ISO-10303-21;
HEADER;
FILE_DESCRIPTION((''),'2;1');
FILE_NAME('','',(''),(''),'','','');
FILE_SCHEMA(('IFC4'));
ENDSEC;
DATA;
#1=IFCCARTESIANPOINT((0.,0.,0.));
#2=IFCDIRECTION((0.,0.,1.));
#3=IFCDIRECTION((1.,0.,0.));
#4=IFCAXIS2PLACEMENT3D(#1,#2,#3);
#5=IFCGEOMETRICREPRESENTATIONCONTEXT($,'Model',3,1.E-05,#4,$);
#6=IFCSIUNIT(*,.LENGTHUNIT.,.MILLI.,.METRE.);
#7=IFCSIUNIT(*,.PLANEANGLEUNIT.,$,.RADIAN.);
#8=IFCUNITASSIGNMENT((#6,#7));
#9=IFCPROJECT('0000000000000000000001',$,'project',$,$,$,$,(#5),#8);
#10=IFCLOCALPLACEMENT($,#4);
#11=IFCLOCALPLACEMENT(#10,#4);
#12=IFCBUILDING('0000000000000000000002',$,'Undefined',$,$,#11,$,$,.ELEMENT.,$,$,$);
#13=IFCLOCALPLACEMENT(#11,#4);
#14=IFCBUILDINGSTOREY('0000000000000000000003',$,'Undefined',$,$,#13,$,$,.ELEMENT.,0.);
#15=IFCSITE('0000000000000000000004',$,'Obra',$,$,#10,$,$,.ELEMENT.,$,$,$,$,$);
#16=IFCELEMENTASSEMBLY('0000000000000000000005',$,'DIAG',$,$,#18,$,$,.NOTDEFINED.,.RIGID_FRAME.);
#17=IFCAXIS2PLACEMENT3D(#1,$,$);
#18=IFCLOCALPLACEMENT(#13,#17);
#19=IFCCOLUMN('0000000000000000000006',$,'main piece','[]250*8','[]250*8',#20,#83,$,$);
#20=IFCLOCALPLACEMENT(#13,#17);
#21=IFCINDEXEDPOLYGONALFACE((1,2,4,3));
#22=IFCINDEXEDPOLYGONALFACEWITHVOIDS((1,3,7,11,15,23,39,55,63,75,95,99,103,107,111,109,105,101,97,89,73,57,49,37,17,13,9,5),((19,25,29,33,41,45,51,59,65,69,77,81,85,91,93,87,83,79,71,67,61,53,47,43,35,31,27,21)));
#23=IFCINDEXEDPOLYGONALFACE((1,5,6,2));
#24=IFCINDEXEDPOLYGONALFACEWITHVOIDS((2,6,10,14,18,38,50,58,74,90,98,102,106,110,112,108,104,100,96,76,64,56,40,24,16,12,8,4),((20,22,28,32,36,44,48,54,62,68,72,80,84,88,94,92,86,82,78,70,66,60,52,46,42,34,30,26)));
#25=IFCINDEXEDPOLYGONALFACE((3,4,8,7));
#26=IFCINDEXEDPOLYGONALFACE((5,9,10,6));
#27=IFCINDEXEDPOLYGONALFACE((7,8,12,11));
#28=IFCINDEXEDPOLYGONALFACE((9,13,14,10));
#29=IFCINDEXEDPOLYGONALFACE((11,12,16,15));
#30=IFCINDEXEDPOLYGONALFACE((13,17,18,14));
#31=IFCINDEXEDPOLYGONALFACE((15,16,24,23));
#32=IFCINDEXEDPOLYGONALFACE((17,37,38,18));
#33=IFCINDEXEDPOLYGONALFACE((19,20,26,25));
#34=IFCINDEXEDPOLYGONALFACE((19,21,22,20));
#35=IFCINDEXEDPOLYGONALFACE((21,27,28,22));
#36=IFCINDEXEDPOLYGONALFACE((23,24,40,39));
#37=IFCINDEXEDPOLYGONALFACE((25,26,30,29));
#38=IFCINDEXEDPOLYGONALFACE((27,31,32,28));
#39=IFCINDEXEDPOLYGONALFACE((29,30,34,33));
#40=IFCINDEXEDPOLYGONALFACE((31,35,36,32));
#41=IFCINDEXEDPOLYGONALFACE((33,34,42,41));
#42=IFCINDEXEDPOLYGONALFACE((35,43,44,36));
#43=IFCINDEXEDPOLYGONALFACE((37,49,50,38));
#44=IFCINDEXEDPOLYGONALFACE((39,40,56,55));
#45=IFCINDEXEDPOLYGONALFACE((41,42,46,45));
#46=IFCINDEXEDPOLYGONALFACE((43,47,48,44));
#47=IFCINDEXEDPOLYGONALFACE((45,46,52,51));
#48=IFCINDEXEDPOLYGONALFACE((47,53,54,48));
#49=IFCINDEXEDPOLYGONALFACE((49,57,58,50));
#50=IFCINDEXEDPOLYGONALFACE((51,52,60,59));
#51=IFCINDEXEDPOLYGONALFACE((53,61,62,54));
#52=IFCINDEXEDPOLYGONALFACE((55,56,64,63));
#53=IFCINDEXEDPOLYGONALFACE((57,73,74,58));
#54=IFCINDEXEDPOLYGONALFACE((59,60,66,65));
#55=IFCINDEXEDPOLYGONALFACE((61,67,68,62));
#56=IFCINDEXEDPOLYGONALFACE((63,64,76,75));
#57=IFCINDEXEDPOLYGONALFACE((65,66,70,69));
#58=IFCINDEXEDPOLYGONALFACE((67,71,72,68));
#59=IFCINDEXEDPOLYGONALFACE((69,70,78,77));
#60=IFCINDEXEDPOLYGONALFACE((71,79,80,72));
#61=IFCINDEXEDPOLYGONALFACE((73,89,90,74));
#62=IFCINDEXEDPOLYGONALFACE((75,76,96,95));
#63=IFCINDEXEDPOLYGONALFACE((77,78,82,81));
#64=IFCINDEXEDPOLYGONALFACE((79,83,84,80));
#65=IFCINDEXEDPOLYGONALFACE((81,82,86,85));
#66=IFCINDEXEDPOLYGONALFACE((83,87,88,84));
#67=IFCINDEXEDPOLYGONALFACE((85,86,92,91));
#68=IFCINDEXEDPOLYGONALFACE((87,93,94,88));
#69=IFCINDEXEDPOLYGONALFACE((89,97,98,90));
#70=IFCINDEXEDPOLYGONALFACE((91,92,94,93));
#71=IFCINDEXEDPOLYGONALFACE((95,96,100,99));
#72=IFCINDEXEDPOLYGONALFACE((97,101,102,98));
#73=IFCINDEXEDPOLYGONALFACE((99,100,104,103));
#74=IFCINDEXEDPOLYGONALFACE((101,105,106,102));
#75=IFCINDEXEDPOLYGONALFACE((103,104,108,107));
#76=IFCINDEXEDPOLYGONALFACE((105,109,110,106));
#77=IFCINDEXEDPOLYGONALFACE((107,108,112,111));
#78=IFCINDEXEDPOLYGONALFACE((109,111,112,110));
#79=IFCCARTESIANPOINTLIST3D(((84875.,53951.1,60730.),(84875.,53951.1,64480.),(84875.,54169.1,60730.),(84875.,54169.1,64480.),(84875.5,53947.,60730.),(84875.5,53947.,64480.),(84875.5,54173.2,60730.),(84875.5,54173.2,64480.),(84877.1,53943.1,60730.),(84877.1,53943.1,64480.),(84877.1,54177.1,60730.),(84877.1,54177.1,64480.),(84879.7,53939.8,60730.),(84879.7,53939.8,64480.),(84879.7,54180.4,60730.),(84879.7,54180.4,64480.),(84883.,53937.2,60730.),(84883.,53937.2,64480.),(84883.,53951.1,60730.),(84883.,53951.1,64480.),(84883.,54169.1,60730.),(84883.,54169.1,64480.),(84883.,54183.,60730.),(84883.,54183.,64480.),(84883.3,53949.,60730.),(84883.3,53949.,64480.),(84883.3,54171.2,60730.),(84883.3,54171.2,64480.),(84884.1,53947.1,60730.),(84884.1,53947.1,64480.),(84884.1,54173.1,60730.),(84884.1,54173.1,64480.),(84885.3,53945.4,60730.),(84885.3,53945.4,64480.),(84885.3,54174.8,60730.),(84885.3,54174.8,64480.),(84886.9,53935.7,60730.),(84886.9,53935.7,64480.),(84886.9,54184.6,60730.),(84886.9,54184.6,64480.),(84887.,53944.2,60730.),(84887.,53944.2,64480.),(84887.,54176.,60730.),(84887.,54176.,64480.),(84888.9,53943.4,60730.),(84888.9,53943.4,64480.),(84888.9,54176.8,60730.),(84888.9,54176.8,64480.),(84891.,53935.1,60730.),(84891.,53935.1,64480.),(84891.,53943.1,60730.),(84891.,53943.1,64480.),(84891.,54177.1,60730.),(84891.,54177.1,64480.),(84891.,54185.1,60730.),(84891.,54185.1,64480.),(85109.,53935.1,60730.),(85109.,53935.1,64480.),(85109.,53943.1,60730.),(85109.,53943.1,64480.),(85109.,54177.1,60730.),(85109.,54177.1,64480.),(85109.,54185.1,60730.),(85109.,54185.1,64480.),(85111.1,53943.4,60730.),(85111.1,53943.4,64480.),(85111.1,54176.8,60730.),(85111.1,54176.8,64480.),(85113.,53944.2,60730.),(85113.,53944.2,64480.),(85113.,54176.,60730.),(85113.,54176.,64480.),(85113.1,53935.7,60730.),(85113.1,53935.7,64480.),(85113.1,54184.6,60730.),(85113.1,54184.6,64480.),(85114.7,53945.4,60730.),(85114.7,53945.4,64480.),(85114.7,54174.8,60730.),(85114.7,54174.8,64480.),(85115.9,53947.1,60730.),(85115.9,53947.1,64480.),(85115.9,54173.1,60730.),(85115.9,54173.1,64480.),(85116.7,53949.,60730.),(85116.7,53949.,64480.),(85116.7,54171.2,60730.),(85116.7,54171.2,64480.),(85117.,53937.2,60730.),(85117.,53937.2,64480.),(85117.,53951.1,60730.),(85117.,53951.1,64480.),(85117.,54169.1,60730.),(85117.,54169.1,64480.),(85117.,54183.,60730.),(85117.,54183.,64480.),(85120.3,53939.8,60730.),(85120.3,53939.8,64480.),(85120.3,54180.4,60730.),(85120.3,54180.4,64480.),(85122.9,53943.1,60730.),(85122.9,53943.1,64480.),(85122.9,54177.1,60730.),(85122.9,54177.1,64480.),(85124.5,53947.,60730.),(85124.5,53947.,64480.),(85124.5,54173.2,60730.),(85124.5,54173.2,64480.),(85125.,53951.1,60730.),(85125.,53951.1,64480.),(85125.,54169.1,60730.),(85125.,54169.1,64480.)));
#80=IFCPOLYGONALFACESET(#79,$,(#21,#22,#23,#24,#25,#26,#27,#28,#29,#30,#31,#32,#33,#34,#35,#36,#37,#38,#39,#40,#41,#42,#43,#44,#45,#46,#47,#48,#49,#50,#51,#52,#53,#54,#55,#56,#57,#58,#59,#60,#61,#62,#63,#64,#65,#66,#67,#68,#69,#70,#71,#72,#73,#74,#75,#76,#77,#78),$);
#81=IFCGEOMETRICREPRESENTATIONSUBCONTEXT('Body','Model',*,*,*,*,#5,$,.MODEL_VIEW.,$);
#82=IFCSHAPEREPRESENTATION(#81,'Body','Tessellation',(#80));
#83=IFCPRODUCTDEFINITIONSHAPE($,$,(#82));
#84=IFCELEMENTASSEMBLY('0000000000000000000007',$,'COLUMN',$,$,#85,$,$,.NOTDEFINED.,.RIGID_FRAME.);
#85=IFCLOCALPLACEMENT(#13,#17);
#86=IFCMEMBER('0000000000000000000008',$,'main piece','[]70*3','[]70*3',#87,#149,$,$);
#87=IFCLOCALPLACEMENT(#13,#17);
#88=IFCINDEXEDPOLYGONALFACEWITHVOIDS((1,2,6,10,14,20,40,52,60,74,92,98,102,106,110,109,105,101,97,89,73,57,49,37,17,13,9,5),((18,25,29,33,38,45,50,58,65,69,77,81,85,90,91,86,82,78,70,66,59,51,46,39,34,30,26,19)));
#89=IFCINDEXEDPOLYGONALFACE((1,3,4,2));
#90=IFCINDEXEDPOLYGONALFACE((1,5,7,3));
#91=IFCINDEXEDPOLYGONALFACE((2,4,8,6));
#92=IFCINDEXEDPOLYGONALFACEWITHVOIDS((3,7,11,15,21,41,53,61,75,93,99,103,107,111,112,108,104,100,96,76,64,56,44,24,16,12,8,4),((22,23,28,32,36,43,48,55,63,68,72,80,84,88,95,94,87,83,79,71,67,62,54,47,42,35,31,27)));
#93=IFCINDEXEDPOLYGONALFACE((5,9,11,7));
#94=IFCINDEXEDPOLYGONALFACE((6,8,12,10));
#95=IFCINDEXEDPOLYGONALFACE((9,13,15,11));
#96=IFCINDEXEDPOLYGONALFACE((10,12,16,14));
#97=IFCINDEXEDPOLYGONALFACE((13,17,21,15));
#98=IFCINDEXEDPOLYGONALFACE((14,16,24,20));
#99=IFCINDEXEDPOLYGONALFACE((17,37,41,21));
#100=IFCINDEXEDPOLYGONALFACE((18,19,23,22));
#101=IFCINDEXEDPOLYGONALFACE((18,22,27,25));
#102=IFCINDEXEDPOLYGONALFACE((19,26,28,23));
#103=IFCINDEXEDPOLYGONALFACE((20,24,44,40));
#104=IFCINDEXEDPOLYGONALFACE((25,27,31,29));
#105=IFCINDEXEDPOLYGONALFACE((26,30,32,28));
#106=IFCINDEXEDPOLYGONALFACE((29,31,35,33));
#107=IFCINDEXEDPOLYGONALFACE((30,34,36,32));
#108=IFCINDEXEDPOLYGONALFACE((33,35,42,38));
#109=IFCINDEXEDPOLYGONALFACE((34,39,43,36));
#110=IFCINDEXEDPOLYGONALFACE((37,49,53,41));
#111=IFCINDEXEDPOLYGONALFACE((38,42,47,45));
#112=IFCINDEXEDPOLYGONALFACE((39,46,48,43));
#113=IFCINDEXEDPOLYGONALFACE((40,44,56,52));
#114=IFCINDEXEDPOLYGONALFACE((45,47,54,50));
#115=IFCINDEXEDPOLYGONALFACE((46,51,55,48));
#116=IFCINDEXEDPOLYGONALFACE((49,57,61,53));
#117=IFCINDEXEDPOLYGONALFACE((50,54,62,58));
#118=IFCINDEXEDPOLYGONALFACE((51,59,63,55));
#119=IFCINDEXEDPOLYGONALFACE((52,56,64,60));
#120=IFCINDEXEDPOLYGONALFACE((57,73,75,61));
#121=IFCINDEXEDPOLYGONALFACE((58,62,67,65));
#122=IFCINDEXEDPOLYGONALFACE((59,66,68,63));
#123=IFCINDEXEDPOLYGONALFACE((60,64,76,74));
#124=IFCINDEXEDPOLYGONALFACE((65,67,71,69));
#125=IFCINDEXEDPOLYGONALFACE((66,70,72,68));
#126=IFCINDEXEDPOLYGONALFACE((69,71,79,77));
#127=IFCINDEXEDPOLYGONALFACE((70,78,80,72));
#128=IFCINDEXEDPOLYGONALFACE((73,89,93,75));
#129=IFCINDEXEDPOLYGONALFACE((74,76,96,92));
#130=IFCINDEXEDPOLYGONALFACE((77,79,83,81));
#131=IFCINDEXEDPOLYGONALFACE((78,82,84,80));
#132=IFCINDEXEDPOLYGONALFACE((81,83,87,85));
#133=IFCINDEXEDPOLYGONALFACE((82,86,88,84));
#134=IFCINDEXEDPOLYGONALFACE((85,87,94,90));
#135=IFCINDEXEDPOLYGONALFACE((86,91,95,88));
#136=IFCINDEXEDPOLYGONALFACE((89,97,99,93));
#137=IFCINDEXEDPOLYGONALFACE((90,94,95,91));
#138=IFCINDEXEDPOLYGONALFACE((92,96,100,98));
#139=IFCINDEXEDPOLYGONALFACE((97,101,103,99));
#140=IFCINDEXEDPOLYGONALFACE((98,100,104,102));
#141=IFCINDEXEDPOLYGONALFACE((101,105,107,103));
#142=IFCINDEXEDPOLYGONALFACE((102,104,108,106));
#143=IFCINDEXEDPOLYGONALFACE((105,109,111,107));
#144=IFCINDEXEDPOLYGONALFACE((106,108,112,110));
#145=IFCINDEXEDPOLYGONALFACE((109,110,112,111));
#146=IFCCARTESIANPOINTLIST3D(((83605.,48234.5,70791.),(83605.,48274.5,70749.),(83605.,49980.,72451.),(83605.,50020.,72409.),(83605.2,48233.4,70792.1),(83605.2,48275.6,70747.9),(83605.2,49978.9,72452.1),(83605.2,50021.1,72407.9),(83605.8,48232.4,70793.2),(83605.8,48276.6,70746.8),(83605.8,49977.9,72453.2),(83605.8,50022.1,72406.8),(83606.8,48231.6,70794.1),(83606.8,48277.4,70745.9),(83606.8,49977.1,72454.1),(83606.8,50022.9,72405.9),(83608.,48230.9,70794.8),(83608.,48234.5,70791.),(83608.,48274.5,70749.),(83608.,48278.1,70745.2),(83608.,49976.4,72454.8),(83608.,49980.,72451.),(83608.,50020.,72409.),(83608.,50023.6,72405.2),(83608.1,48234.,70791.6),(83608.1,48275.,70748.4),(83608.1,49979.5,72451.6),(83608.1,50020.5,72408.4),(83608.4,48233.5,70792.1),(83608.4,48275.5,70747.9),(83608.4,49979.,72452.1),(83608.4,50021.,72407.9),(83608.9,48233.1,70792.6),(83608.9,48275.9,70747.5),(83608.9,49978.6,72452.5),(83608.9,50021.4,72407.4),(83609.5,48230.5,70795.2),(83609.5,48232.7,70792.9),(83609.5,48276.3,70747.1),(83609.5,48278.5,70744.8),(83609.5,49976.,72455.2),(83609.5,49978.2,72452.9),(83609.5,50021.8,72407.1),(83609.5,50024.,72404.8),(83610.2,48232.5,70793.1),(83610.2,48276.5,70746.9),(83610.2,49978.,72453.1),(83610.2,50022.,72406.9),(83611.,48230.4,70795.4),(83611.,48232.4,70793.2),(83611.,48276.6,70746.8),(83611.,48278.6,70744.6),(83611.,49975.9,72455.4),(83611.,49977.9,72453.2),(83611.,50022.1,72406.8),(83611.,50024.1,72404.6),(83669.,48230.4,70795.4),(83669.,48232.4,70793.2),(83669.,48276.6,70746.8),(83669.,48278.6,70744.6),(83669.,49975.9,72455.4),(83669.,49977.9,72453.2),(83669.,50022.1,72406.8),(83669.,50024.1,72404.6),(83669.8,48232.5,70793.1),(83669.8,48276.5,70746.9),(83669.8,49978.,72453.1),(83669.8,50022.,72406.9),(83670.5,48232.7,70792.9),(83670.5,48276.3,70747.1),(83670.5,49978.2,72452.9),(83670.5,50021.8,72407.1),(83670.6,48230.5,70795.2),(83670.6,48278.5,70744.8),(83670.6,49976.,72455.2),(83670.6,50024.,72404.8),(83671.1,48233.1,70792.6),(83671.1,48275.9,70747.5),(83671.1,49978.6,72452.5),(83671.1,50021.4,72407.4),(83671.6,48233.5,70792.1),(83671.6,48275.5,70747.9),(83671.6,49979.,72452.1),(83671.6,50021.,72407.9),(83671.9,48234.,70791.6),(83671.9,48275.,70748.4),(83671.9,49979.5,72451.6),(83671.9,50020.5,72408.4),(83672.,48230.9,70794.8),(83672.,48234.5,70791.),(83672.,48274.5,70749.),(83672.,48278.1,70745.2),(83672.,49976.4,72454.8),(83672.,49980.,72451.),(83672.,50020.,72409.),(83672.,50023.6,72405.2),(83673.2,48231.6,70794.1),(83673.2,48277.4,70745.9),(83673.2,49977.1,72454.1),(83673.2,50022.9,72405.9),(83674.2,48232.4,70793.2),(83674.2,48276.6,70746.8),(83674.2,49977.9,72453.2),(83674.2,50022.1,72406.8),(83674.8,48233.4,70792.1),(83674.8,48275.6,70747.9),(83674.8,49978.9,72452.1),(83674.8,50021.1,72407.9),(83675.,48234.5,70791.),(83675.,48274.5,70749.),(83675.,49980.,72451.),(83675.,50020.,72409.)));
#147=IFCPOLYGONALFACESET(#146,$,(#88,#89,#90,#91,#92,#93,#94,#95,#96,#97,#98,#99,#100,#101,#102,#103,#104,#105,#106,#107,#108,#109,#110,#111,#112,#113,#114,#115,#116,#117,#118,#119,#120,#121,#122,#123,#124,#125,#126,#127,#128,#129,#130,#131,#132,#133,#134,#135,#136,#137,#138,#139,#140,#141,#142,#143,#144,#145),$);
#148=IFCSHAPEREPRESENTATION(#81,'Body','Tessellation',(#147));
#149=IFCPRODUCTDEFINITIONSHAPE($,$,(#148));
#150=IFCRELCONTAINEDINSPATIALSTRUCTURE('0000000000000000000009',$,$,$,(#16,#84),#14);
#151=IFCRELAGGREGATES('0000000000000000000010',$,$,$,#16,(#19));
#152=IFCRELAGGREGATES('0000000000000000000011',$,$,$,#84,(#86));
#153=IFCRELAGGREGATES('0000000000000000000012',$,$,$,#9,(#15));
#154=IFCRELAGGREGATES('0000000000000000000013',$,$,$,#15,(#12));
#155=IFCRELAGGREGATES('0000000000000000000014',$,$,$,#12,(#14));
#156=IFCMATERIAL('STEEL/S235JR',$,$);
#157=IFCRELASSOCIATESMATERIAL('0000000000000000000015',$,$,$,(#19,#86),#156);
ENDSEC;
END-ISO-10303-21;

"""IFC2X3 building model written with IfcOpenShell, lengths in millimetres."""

from ifc_helpers import new_model, si_unit, frame, origin_with_axes, origin_2d_with_axis, place, context, subcontext, project, spatial, hollow_rectangle, extrude, material, element, aggregate, save


model = new_model("IFC2X3")

# Units and contexts
model_context = context("Model", 3, precision=1e-05, world=origin_with_axes())
body_context = subcontext(model_context, "Body", "Model", "MODEL_VIEW")
ifc_project = project(units=[si_unit("LENGTHUNIT", "METRE", prefix="MILLI"), si_unit("PLANEANGLEUNIT", "RADIAN")], contexts=[model_context])

# Site, building, storey
site_placement = place(None, origin_with_axes())
site = spatial("IfcSite", under=ifc_project, at=site_placement, Name="Obra", CompositionType="ELEMENT")
building_placement = place(site_placement, origin_with_axes())
building = spatial("IfcBuilding", under=site, at=building_placement, Name="Undefined", CompositionType="ELEMENT")
storey_placement = place(building_placement, origin_with_axes())
storey = spatial("IfcBuildingStorey", under=building, at=storey_placement, Name="Undefined", CompositionType="ELEMENT", Elevation=0.0)

# Element assembly, column
ifc_material = material(Name="STEEL/S235JR")
assembly_1_placement = place(storey_placement, origin_with_axes())
assembly_1 = element("IfcElementAssembly", 1, at=assembly_1_placement, inside=storey, Name="DIAG", AssemblyPlace="NOTDEFINED", PredefinedType="RIGID_FRAME")
column_1_placement = place(assembly_1_placement, frame((85000.0, 54060.1, 60730.0), z_axis=(0.0, 0.0, 1.0), x_axis=(-1.0, 0.0, 0.0)))
column_1 = element("IfcColumn", 2, at=column_1_placement, material=ifc_material, Name="main piece", Description="[]250*8", ObjectType="[]250*8", context=body_context, shape_type="SweptSolid", body=[
    extrude(hollow_rectangle(XDim=250.0, YDim=250.0, WallThickness=8.0, InnerFilletRadius=8.0, OuterFilletRadius=16.0, at=origin_2d_with_axis()), frame((0.0, 0.0, 3750.0), z_axis=(0.0, 0.0, -1.0), x_axis=(0.0, 1.0, 0.0)), (0.0, 0.0, 1.0), 3750.0),
])
aggregate(assembly_1, [column_1])

# Element assembly, member
assembly_2_placement = place(storey_placement, origin_with_axes())
assembly_2 = element("IfcElementAssembly", 3, at=assembly_2_placement, inside=storey, Name="COLUMN", AssemblyPlace="NOTDEFINED", PredefinedType="RIGID_FRAME")
member_1_placement = place(assembly_2_placement, frame((83640.0, 48254.5, 70770.0), z_axis=(-1.0, 0.0, 0.0), x_axis=(0.0, 0.724633, 0.689135)))
member_1 = element("IfcMember", 4, at=member_1_placement, material=ifc_material, Name="main piece", Description="[]70*3", ObjectType="[]70*3", context=body_context, shape_type="SweptSolid", body=[
    extrude(hollow_rectangle(XDim=70.0, YDim=70.0, WallThickness=3.0, InnerFilletRadius=3.0, OuterFilletRadius=6.0, at=origin_2d_with_axis()), frame((2408.8, 0.0, 0.0), z_axis=(-1.0, 0.0, 0.0), x_axis=(0.0, -1.0, 0.0)), (0.0, 0.0, 1.0), 2408.8),
])
aggregate(assembly_2, [member_1])

save(model, "model.ifc")
